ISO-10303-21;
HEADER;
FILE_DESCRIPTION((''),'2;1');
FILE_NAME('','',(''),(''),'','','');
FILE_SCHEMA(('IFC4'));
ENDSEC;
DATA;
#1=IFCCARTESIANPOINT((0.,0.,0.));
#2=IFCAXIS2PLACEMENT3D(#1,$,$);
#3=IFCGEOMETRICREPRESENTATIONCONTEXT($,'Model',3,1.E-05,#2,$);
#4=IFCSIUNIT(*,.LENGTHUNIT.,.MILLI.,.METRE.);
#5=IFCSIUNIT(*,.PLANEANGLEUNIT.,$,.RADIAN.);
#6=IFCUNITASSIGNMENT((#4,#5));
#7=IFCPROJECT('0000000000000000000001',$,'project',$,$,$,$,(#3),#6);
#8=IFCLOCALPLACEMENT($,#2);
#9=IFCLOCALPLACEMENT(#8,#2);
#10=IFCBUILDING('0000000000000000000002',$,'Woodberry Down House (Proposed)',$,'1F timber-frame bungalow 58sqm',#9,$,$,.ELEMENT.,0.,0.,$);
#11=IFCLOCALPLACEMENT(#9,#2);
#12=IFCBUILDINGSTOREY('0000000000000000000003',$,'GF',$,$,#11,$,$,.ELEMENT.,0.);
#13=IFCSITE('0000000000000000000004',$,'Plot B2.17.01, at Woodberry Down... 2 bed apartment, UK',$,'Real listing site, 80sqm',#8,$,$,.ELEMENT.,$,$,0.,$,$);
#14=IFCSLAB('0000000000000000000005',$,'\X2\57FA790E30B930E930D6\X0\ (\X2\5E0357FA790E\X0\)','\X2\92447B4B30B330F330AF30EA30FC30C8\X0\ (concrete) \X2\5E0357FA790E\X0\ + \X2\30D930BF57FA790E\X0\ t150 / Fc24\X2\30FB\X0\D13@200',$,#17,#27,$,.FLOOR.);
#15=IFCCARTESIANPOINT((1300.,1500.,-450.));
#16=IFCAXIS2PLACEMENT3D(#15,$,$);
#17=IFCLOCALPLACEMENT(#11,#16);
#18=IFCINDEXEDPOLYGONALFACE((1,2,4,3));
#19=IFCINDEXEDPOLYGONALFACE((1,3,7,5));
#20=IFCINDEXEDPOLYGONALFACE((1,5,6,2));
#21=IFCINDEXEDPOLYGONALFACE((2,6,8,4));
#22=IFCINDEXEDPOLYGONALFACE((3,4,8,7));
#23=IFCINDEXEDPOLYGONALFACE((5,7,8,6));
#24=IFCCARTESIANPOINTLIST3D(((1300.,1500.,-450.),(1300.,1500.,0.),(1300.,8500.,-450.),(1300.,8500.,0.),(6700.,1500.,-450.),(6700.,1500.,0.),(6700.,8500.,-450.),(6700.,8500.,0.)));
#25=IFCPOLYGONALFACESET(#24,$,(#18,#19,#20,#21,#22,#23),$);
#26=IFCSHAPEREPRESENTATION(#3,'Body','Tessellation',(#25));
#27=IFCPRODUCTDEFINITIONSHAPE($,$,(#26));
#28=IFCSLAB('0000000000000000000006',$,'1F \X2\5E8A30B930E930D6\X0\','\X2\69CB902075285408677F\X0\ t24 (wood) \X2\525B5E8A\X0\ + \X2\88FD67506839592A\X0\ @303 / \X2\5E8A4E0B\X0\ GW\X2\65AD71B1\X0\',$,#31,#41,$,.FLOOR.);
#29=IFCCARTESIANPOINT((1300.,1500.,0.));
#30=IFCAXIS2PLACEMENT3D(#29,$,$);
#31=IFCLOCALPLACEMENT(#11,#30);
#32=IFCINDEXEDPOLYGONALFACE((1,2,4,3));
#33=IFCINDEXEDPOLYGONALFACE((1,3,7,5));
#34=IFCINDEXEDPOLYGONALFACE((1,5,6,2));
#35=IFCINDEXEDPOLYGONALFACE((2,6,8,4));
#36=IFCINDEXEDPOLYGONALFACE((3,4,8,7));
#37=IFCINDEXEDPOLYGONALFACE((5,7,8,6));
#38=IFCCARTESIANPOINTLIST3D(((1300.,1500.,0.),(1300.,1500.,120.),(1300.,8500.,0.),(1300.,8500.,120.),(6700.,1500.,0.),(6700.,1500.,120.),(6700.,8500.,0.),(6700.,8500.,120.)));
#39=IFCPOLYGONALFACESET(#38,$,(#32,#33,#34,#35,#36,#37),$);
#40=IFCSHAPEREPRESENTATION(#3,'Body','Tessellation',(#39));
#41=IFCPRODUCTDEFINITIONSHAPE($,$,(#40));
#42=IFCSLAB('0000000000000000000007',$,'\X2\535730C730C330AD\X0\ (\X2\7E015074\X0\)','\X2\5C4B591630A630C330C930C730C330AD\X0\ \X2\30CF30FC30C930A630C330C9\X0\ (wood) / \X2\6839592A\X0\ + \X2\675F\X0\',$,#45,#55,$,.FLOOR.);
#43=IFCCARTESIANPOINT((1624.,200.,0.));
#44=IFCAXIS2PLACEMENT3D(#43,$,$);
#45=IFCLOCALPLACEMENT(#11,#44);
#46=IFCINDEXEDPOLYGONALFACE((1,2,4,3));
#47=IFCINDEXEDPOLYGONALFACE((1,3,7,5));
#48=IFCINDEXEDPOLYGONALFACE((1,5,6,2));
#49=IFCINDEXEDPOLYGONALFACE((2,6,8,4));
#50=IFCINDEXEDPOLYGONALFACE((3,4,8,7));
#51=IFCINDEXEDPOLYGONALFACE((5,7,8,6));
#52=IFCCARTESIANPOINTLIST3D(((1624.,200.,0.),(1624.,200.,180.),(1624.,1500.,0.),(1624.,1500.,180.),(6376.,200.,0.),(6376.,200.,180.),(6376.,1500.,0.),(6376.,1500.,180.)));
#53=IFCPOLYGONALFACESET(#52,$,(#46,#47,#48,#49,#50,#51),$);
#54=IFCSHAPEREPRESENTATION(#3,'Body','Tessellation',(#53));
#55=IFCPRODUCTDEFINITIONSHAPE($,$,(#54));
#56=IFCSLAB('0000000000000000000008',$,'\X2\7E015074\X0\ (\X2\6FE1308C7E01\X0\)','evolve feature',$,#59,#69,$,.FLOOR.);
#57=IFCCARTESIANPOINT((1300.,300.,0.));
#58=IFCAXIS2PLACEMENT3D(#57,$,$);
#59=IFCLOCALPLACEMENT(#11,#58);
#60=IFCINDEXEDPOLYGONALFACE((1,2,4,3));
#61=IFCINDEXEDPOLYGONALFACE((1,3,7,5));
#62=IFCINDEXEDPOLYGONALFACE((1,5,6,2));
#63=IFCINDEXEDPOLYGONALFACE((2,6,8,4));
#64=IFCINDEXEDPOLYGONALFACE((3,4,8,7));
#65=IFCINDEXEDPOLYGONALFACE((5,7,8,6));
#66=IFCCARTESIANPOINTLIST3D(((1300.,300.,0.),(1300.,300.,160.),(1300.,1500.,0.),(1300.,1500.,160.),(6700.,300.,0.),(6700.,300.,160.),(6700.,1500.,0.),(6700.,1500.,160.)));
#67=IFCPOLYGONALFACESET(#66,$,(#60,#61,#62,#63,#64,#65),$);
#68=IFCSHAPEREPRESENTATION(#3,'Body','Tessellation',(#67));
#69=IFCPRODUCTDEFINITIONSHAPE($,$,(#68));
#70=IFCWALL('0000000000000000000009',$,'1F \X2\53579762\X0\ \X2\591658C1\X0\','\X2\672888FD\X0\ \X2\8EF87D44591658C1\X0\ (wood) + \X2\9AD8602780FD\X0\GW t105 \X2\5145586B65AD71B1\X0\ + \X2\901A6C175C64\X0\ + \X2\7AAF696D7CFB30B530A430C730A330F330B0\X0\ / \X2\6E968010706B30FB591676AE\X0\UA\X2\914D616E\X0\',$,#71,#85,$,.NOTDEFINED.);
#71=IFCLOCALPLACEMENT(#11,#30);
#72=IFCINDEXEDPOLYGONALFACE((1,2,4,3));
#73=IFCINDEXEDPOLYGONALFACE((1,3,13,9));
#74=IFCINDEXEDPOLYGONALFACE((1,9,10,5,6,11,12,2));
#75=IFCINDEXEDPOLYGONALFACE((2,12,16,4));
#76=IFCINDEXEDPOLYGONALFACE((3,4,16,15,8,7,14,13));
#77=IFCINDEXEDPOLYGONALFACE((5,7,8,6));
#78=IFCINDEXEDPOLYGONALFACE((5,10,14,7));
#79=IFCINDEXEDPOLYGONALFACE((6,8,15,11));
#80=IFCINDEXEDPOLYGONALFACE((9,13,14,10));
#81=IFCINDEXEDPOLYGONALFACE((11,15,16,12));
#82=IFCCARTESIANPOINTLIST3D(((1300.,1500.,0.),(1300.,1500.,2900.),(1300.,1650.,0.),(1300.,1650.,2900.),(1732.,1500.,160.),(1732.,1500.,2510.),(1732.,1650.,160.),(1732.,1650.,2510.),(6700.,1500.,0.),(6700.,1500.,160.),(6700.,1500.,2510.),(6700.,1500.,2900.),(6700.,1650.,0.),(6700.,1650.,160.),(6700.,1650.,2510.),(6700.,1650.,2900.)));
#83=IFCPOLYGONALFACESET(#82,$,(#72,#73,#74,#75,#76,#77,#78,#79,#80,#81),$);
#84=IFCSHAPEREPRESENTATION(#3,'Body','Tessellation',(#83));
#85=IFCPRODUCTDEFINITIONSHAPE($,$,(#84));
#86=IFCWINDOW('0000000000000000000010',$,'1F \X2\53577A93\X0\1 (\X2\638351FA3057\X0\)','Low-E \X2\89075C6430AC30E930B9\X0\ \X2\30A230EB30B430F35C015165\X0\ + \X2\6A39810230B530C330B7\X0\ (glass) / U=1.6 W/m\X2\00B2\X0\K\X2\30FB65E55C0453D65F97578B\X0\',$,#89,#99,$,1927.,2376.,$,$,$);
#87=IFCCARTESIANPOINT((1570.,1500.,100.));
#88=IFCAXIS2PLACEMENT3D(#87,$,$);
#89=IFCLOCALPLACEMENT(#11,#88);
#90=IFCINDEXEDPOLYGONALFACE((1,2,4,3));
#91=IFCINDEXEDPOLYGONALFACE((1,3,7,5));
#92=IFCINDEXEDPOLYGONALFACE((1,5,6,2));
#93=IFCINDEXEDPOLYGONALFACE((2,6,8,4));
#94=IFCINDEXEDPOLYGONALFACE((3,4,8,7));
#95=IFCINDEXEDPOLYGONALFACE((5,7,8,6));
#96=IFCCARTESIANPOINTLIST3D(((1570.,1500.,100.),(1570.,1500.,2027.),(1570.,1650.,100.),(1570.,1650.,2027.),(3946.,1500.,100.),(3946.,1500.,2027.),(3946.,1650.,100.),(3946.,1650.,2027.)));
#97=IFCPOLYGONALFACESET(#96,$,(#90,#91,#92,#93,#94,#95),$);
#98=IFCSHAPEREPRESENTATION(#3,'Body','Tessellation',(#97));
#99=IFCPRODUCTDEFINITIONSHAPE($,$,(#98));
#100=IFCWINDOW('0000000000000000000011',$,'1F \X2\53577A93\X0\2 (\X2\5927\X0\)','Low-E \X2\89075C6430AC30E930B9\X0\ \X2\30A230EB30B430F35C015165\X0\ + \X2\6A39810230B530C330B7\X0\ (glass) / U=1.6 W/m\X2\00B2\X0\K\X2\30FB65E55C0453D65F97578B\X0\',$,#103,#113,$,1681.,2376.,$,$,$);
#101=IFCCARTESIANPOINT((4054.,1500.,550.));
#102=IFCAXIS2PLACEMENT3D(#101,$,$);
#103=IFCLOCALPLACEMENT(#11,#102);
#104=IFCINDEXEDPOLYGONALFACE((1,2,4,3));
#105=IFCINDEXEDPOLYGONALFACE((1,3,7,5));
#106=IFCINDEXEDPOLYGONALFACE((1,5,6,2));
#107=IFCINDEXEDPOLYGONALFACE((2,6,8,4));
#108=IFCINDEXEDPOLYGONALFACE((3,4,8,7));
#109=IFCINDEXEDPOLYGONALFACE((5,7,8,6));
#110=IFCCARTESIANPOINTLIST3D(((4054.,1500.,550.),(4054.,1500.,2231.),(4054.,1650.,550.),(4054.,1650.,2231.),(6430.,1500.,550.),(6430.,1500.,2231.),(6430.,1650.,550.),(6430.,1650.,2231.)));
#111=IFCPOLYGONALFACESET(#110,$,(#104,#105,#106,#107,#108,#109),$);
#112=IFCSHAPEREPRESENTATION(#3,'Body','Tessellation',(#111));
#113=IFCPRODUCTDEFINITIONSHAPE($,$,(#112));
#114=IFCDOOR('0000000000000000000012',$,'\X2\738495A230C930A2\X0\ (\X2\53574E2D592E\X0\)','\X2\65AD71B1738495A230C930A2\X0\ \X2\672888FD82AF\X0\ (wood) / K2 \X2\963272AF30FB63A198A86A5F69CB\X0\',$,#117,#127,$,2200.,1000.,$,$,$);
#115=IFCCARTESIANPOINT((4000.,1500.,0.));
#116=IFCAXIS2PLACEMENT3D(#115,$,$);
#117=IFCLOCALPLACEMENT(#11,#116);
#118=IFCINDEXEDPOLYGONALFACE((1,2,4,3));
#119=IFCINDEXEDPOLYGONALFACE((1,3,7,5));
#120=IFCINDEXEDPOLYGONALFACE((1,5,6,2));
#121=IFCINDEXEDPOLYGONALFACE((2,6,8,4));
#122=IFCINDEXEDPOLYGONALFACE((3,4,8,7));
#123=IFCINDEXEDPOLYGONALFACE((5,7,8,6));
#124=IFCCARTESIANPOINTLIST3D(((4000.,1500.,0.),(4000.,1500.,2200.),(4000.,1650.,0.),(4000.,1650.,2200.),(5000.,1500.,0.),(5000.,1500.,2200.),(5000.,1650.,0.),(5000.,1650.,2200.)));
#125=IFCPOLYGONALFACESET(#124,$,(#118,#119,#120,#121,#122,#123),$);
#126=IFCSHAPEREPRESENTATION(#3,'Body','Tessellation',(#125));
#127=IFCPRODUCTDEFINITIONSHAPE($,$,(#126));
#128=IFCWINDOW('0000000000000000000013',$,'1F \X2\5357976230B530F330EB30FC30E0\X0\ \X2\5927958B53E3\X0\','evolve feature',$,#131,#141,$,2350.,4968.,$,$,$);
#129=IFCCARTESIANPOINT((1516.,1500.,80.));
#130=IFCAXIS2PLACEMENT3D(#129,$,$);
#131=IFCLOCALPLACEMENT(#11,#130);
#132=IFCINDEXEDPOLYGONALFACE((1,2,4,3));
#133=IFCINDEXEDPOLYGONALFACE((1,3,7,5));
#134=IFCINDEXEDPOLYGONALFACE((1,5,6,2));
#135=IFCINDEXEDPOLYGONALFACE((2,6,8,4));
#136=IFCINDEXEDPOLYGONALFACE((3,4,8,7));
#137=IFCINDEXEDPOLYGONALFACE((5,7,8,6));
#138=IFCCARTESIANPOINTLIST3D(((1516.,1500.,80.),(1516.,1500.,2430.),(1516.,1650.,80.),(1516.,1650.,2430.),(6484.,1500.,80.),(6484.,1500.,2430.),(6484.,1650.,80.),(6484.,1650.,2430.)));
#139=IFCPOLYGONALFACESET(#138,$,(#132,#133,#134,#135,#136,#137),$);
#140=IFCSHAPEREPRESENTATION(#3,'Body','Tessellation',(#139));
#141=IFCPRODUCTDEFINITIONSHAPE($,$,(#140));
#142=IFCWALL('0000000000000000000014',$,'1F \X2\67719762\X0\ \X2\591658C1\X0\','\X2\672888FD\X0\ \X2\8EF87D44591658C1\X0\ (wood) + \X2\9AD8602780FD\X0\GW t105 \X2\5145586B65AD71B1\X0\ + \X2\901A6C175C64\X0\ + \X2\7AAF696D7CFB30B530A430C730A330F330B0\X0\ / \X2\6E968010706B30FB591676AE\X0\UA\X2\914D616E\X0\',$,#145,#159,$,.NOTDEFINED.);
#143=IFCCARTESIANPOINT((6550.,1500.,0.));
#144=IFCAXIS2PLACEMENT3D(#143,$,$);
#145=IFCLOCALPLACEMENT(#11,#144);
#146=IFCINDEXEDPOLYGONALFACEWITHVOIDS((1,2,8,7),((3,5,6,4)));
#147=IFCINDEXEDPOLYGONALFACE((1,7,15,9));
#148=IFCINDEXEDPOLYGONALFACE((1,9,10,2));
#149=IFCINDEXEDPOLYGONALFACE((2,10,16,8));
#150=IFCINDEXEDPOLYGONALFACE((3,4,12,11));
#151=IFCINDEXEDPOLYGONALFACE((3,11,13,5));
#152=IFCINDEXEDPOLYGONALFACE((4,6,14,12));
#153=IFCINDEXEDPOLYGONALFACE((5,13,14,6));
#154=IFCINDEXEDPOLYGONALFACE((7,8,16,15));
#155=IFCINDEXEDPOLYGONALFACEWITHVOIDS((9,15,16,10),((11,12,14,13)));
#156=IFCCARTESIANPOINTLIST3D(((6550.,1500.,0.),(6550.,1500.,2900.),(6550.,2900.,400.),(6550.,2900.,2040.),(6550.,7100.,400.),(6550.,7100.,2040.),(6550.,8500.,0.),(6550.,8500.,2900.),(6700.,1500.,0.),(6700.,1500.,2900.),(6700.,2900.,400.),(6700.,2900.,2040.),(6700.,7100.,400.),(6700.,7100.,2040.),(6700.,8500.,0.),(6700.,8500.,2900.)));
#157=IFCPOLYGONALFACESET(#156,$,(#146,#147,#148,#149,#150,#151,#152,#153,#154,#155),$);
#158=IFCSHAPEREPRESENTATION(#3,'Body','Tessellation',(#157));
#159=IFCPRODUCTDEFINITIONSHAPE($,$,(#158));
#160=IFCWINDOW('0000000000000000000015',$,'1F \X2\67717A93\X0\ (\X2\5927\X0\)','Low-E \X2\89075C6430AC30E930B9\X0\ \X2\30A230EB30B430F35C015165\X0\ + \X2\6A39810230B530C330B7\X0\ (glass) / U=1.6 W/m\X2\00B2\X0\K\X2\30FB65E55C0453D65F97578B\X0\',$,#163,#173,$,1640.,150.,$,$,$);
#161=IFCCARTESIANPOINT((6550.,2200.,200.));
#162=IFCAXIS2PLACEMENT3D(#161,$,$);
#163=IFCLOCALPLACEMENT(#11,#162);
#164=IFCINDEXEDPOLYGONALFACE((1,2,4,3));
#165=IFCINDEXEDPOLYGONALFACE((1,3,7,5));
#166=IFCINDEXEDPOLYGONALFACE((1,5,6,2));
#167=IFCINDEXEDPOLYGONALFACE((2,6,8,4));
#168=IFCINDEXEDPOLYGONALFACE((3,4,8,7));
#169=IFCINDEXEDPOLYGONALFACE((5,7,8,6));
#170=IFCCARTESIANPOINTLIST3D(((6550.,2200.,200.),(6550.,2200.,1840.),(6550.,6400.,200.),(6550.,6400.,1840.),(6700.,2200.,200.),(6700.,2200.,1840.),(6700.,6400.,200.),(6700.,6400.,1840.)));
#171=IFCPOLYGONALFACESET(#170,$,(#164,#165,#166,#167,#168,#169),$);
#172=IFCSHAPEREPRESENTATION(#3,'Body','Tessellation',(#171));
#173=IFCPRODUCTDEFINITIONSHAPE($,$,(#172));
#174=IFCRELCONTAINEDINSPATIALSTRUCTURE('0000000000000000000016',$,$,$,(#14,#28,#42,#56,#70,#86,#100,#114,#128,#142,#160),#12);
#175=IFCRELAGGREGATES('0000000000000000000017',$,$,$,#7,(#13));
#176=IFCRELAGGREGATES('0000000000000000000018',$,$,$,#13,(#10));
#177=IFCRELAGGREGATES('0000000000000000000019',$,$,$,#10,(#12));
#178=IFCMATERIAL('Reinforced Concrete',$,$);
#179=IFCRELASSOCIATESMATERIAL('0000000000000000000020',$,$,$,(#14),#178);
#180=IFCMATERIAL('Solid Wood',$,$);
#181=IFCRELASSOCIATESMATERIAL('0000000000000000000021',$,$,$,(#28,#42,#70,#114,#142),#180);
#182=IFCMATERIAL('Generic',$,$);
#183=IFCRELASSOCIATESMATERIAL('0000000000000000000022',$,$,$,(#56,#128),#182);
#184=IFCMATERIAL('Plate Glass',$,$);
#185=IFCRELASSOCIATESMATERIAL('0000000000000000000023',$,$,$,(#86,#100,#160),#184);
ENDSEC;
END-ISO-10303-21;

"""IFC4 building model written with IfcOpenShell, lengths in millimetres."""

from ifc_helpers import new_model, si_unit, frame, frame_2d, origin, place, context, project, spatial, rectangle, extrude, material, element, fill, save


model = new_model("IFC4")

# Units and contexts
model_context = context("Model", 3, precision=1e-05, world=origin())
ifc_project = project(units=[si_unit("LENGTHUNIT", "METRE", prefix="MILLI"), si_unit("PLANEANGLEUNIT", "RADIAN")], contexts=[model_context])

# Site, building, storey
site_placement = place(None, origin())
site = spatial("IfcSite", under=ifc_project, at=site_placement, Name="Plot B2.17.01, at Woodberry Down... 2 bed apartment, UK", ObjectType="Real listing site, 80sqm", CompositionType="ELEMENT", RefElevation=0.0)
building_placement = place(site_placement, origin())
building = spatial("IfcBuilding", under=site, at=building_placement, Name="Woodberry Down House (Proposed)", ObjectType="1F timber-frame bungalow 58sqm", CompositionType="ELEMENT", ElevationOfRefHeight=0.0, ElevationOfTerrain=0.0)
storey_placement = place(building_placement, origin())
storey = spatial("IfcBuildingStorey", under=building, at=storey_placement, Name="GF", CompositionType="ELEMENT", Elevation=0.0)

# Slabs
ifc_material_1 = material(Name="Reinforced Concrete")
slab_1_placement = place(storey_placement, frame((1300.0, 1500.0, -450.0)))
element("IfcSlab", 1, at=slab_1_placement, inside=storey, material=ifc_material_1, Name="基礎スラブ (布基礎)", Description="鉄筋コンクリート (concrete) 布基礎 + ベタ基礎 t150 / Fc24・D13@200", PredefinedType="FLOOR", context=model_context, shape_type="SweptSolid", body=[
    extrude(rectangle(XDim=5400.0, YDim=7000.0, at=frame_2d((2700.0, 3500.0))), frame((1300.0, 1500.0, -450.0)), (0.0, 0.0, 1.0), 450.0),
])
ifc_material_2 = material(Name="Solid Wood")
slab_2_placement = place(storey_placement, frame((1300.0, 1500.0, 0.0)))
element("IfcSlab", 2, at=slab_2_placement, inside=storey, material=ifc_material_2, Name="1F 床スラブ", Description="構造用合板 t24 (wood) 剛床 + 製材根太 @303 / 床下 GW断熱", PredefinedType="FLOOR", context=model_context, shape_type="SweptSolid", body=[
    extrude(rectangle(XDim=5400.0, YDim=7000.0, at=frame_2d((2700.0, 3500.0))), frame((1300.0, 1500.0, 0.0)), (0.0, 0.0, 1.0), 120.0),
])
slab_3_placement = place(storey_placement, frame((1624.0, 200.0, 0.0)))
element("IfcSlab", 3, at=slab_3_placement, inside=storey, material=ifc_material_2, Name="南デッキ (縁側)", Description="屋外ウッドデッキ ハードウッド (wood) / 根太 + 束", PredefinedType="FLOOR", context=model_context, shape_type="SweptSolid", body=[
    extrude(rectangle(XDim=4752.0, YDim=1300.0, at=frame_2d((2376.0, 650.0))), frame((1624.0, 200.0, 0.0)), (0.0, 0.0, 1.0), 180.0),
])
ifc_material_3 = material(Name="Generic")
slab_4_placement = place(storey_placement, frame((1300.0, 300.0, 0.0)))
element("IfcSlab", 4, at=slab_4_placement, inside=storey, material=ifc_material_3, Name="縁側 (濡れ縁)", Description="evolve feature", PredefinedType="FLOOR", context=model_context, shape_type="SweptSolid", body=[
    extrude(rectangle(XDim=5400.0, YDim=1200.0, at=frame_2d((2700.0, 600.0))), frame((1300.0, 300.0, 0.0)), (0.0, 0.0, 1.0), 160.0),
])

# Wall, openings, windows, door
wall_1_placement = place(storey_placement, frame((1300.0, 1500.0, 0.0)))
wall_1 = element("IfcWall", 5, at=wall_1_placement, inside=storey, material=ifc_material_2, Name="1F 南面 外壁", Description="木製 軸組外壁 (wood) + 高性能GW t105 充填断熱 + 通気層 + 窯業系サイディング / 準耐火・外皮UA配慮", PredefinedType="NOTDEFINED", context=model_context, shape_type="SweptSolid", body=[
    extrude(rectangle(XDim=5400.0, YDim=150.0, at=frame_2d((2700.0, 75.0))), frame((1300.0, 1500.0, 0.0)), (0.0, 0.0, 1.0), 2900.0),
])
opening_1_placement = place(storey_placement, frame((1570.0, 1500.0, 100.0)))
opening_1 = element("IfcOpeningElement", 6, at=opening_1_placement, cuts=wall_1, PredefinedType="NOTDEFINED", context=model_context, shape_type="SweptSolid", body=[
    extrude(rectangle(XDim=2376.0, YDim=150.0, at=frame_2d((1188.0, 75.0))), frame((1570.0, 1500.0, 100.0)), (0.0, 0.0, 1.0), 1927.0),
])
opening_2_placement = place(storey_placement, frame((4054.0, 1500.0, 550.0)))
opening_2 = element("IfcOpeningElement", 7, at=opening_2_placement, cuts=wall_1, PredefinedType="NOTDEFINED", context=model_context, shape_type="SweptSolid", body=[
    extrude(rectangle(XDim=2376.0, YDim=150.0, at=frame_2d((1188.0, 75.0))), frame((4054.0, 1500.0, 550.0)), (0.0, 0.0, 1.0), 1681.0),
])
opening_3_placement = place(storey_placement, frame((4000.0, 1500.0, 0.0)))
opening_3 = element("IfcOpeningElement", 8, at=opening_3_placement, cuts=wall_1, PredefinedType="NOTDEFINED", context=model_context, shape_type="SweptSolid", body=[
    extrude(rectangle(XDim=1000.0, YDim=150.0, at=frame_2d((500.0, 75.0))), frame((4000.0, 1500.0, 0.0)), (0.0, 0.0, 1.0), 2200.0),
])
opening_4_placement = place(storey_placement, frame((1516.0, 1500.0, 80.0)))
opening_4 = element("IfcOpeningElement", 9, at=opening_4_placement, cuts=wall_1, PredefinedType="NOTDEFINED", context=model_context, shape_type="SweptSolid", body=[
    extrude(rectangle(XDim=4968.0, YDim=150.0, at=frame_2d((2484.0, 75.0))), frame((1516.0, 1500.0, 80.0)), (0.0, 0.0, 1.0), 2350.0),
])
ifc_material_4 = material(Name="Plate Glass")
window_1_placement = place(storey_placement, frame((1570.0, 1500.0, 100.0)))
window_1 = element("IfcWindow", 10, at=window_1_placement, inside=storey, material=ifc_material_4, Name="1F 南窓1 (掃出し)", Description="Low-E 複層ガラス アルゴン封入 + 樹脂サッシ (glass) / U=1.6 W/m²K・日射取得型", OverallHeight=1927.0, OverallWidth=2376.0, context=model_context, shape_type="SweptSolid", body=[
    extrude(rectangle(XDim=2376.0, YDim=150.0, at=frame_2d((1188.0, 75.0))), frame((1570.0, 1500.0, 100.0)), (0.0, 0.0, 1.0), 1927.0),
])
fill(opening_1, window_1)
window_2_placement = place(storey_placement, frame((4054.0, 1500.0, 550.0)))
window_2 = element("IfcWindow", 11, at=window_2_placement, inside=storey, material=ifc_material_4, Name="1F 南窓2 (大)", Description="Low-E 複層ガラス アルゴン封入 + 樹脂サッシ (glass) / U=1.6 W/m²K・日射取得型", OverallHeight=1681.0, OverallWidth=2376.0, context=model_context, shape_type="SweptSolid", body=[
    extrude(rectangle(XDim=2376.0, YDim=150.0, at=frame_2d((1188.0, 75.0))), frame((4054.0, 1500.0, 550.0)), (0.0, 0.0, 1.0), 1681.0),
])
fill(opening_2, window_2)
door_placement = place(storey_placement, frame((4000.0, 1500.0, 0.0)))
door = element("IfcDoor", 12, at=door_placement, inside=storey, material=ifc_material_2, Name="玄関ドア (南中央)", Description="断熱玄関ドア 木製芯 (wood) / K2 防犯・採風機構", OverallHeight=2200.0, OverallWidth=1000.0, context=model_context, shape_type="SweptSolid", body=[
    extrude(rectangle(XDim=1000.0, YDim=150.0, at=frame_2d((500.0, 75.0))), frame((4000.0, 1500.0, 0.0)), (0.0, 0.0, 1.0), 2200.0),
])
fill(opening_3, door)
window_3_placement = place(storey_placement, frame((1516.0, 1500.0, 80.0)))
window_3 = element("IfcWindow", 13, at=window_3_placement, inside=storey, material=ifc_material_3, Name="1F 南面サンルーム 大開口", Description="evolve feature", OverallHeight=2350.0, OverallWidth=4968.0, context=model_context, shape_type="SweptSolid", body=[
    extrude(rectangle(XDim=4968.0, YDim=150.0, at=frame_2d((2484.0, 75.0))), frame((1516.0, 1500.0, 80.0)), (0.0, 0.0, 1.0), 2350.0),
])
fill(opening_4, window_3)

# Wall, opening, window
wall_2_placement = place(storey_placement, frame((6550.0, 1500.0, 0.0)))
wall_2 = element("IfcWall", 14, at=wall_2_placement, inside=storey, material=ifc_material_2, Name="1F 東面 外壁", Description="木製 軸組外壁 (wood) + 高性能GW t105 充填断熱 + 通気層 + 窯業系サイディング / 準耐火・外皮UA配慮", PredefinedType="NOTDEFINED", context=model_context, shape_type="SweptSolid", body=[
    extrude(rectangle(XDim=150.0, YDim=7000.0, at=frame_2d((75.0, 3500.0))), frame((6550.0, 1500.0, 0.0)), (0.0, 0.0, 1.0), 2900.0),
])
opening_5_placement = place(storey_placement, frame((6550.0, 2200.0, 200.0)))
opening_5 = element("IfcOpeningElement", 15, at=opening_5_placement, cuts=wall_2, PredefinedType="NOTDEFINED", context=model_context, shape_type="SweptSolid", body=[
    extrude(rectangle(XDim=150.0, YDim=4200.0, at=frame_2d((75.0, 2100.0))), frame((6550.0, 2200.0, 200.0)), (0.0, 0.0, 1.0), 1640.0),
])
window_4_placement = place(storey_placement, frame((6550.0, 2200.0, 200.0)))
window_4 = element("IfcWindow", 16, at=window_4_placement, inside=storey, material=ifc_material_4, Name="1F 東窓 (大)", Description="Low-E 複層ガラス アルゴン封入 + 樹脂サッシ (glass) / U=1.6 W/m²K・日射取得型", OverallHeight=1640.0, OverallWidth=150.0, context=model_context, shape_type="SweptSolid", body=[
    extrude(rectangle(XDim=150.0, YDim=4200.0, at=frame_2d((75.0, 2100.0))), frame((6550.0, 2200.0, 200.0)), (0.0, 0.0, 1.0), 1640.0),
])
fill(opening_5, window_4)

save(model, "model.ifc")
